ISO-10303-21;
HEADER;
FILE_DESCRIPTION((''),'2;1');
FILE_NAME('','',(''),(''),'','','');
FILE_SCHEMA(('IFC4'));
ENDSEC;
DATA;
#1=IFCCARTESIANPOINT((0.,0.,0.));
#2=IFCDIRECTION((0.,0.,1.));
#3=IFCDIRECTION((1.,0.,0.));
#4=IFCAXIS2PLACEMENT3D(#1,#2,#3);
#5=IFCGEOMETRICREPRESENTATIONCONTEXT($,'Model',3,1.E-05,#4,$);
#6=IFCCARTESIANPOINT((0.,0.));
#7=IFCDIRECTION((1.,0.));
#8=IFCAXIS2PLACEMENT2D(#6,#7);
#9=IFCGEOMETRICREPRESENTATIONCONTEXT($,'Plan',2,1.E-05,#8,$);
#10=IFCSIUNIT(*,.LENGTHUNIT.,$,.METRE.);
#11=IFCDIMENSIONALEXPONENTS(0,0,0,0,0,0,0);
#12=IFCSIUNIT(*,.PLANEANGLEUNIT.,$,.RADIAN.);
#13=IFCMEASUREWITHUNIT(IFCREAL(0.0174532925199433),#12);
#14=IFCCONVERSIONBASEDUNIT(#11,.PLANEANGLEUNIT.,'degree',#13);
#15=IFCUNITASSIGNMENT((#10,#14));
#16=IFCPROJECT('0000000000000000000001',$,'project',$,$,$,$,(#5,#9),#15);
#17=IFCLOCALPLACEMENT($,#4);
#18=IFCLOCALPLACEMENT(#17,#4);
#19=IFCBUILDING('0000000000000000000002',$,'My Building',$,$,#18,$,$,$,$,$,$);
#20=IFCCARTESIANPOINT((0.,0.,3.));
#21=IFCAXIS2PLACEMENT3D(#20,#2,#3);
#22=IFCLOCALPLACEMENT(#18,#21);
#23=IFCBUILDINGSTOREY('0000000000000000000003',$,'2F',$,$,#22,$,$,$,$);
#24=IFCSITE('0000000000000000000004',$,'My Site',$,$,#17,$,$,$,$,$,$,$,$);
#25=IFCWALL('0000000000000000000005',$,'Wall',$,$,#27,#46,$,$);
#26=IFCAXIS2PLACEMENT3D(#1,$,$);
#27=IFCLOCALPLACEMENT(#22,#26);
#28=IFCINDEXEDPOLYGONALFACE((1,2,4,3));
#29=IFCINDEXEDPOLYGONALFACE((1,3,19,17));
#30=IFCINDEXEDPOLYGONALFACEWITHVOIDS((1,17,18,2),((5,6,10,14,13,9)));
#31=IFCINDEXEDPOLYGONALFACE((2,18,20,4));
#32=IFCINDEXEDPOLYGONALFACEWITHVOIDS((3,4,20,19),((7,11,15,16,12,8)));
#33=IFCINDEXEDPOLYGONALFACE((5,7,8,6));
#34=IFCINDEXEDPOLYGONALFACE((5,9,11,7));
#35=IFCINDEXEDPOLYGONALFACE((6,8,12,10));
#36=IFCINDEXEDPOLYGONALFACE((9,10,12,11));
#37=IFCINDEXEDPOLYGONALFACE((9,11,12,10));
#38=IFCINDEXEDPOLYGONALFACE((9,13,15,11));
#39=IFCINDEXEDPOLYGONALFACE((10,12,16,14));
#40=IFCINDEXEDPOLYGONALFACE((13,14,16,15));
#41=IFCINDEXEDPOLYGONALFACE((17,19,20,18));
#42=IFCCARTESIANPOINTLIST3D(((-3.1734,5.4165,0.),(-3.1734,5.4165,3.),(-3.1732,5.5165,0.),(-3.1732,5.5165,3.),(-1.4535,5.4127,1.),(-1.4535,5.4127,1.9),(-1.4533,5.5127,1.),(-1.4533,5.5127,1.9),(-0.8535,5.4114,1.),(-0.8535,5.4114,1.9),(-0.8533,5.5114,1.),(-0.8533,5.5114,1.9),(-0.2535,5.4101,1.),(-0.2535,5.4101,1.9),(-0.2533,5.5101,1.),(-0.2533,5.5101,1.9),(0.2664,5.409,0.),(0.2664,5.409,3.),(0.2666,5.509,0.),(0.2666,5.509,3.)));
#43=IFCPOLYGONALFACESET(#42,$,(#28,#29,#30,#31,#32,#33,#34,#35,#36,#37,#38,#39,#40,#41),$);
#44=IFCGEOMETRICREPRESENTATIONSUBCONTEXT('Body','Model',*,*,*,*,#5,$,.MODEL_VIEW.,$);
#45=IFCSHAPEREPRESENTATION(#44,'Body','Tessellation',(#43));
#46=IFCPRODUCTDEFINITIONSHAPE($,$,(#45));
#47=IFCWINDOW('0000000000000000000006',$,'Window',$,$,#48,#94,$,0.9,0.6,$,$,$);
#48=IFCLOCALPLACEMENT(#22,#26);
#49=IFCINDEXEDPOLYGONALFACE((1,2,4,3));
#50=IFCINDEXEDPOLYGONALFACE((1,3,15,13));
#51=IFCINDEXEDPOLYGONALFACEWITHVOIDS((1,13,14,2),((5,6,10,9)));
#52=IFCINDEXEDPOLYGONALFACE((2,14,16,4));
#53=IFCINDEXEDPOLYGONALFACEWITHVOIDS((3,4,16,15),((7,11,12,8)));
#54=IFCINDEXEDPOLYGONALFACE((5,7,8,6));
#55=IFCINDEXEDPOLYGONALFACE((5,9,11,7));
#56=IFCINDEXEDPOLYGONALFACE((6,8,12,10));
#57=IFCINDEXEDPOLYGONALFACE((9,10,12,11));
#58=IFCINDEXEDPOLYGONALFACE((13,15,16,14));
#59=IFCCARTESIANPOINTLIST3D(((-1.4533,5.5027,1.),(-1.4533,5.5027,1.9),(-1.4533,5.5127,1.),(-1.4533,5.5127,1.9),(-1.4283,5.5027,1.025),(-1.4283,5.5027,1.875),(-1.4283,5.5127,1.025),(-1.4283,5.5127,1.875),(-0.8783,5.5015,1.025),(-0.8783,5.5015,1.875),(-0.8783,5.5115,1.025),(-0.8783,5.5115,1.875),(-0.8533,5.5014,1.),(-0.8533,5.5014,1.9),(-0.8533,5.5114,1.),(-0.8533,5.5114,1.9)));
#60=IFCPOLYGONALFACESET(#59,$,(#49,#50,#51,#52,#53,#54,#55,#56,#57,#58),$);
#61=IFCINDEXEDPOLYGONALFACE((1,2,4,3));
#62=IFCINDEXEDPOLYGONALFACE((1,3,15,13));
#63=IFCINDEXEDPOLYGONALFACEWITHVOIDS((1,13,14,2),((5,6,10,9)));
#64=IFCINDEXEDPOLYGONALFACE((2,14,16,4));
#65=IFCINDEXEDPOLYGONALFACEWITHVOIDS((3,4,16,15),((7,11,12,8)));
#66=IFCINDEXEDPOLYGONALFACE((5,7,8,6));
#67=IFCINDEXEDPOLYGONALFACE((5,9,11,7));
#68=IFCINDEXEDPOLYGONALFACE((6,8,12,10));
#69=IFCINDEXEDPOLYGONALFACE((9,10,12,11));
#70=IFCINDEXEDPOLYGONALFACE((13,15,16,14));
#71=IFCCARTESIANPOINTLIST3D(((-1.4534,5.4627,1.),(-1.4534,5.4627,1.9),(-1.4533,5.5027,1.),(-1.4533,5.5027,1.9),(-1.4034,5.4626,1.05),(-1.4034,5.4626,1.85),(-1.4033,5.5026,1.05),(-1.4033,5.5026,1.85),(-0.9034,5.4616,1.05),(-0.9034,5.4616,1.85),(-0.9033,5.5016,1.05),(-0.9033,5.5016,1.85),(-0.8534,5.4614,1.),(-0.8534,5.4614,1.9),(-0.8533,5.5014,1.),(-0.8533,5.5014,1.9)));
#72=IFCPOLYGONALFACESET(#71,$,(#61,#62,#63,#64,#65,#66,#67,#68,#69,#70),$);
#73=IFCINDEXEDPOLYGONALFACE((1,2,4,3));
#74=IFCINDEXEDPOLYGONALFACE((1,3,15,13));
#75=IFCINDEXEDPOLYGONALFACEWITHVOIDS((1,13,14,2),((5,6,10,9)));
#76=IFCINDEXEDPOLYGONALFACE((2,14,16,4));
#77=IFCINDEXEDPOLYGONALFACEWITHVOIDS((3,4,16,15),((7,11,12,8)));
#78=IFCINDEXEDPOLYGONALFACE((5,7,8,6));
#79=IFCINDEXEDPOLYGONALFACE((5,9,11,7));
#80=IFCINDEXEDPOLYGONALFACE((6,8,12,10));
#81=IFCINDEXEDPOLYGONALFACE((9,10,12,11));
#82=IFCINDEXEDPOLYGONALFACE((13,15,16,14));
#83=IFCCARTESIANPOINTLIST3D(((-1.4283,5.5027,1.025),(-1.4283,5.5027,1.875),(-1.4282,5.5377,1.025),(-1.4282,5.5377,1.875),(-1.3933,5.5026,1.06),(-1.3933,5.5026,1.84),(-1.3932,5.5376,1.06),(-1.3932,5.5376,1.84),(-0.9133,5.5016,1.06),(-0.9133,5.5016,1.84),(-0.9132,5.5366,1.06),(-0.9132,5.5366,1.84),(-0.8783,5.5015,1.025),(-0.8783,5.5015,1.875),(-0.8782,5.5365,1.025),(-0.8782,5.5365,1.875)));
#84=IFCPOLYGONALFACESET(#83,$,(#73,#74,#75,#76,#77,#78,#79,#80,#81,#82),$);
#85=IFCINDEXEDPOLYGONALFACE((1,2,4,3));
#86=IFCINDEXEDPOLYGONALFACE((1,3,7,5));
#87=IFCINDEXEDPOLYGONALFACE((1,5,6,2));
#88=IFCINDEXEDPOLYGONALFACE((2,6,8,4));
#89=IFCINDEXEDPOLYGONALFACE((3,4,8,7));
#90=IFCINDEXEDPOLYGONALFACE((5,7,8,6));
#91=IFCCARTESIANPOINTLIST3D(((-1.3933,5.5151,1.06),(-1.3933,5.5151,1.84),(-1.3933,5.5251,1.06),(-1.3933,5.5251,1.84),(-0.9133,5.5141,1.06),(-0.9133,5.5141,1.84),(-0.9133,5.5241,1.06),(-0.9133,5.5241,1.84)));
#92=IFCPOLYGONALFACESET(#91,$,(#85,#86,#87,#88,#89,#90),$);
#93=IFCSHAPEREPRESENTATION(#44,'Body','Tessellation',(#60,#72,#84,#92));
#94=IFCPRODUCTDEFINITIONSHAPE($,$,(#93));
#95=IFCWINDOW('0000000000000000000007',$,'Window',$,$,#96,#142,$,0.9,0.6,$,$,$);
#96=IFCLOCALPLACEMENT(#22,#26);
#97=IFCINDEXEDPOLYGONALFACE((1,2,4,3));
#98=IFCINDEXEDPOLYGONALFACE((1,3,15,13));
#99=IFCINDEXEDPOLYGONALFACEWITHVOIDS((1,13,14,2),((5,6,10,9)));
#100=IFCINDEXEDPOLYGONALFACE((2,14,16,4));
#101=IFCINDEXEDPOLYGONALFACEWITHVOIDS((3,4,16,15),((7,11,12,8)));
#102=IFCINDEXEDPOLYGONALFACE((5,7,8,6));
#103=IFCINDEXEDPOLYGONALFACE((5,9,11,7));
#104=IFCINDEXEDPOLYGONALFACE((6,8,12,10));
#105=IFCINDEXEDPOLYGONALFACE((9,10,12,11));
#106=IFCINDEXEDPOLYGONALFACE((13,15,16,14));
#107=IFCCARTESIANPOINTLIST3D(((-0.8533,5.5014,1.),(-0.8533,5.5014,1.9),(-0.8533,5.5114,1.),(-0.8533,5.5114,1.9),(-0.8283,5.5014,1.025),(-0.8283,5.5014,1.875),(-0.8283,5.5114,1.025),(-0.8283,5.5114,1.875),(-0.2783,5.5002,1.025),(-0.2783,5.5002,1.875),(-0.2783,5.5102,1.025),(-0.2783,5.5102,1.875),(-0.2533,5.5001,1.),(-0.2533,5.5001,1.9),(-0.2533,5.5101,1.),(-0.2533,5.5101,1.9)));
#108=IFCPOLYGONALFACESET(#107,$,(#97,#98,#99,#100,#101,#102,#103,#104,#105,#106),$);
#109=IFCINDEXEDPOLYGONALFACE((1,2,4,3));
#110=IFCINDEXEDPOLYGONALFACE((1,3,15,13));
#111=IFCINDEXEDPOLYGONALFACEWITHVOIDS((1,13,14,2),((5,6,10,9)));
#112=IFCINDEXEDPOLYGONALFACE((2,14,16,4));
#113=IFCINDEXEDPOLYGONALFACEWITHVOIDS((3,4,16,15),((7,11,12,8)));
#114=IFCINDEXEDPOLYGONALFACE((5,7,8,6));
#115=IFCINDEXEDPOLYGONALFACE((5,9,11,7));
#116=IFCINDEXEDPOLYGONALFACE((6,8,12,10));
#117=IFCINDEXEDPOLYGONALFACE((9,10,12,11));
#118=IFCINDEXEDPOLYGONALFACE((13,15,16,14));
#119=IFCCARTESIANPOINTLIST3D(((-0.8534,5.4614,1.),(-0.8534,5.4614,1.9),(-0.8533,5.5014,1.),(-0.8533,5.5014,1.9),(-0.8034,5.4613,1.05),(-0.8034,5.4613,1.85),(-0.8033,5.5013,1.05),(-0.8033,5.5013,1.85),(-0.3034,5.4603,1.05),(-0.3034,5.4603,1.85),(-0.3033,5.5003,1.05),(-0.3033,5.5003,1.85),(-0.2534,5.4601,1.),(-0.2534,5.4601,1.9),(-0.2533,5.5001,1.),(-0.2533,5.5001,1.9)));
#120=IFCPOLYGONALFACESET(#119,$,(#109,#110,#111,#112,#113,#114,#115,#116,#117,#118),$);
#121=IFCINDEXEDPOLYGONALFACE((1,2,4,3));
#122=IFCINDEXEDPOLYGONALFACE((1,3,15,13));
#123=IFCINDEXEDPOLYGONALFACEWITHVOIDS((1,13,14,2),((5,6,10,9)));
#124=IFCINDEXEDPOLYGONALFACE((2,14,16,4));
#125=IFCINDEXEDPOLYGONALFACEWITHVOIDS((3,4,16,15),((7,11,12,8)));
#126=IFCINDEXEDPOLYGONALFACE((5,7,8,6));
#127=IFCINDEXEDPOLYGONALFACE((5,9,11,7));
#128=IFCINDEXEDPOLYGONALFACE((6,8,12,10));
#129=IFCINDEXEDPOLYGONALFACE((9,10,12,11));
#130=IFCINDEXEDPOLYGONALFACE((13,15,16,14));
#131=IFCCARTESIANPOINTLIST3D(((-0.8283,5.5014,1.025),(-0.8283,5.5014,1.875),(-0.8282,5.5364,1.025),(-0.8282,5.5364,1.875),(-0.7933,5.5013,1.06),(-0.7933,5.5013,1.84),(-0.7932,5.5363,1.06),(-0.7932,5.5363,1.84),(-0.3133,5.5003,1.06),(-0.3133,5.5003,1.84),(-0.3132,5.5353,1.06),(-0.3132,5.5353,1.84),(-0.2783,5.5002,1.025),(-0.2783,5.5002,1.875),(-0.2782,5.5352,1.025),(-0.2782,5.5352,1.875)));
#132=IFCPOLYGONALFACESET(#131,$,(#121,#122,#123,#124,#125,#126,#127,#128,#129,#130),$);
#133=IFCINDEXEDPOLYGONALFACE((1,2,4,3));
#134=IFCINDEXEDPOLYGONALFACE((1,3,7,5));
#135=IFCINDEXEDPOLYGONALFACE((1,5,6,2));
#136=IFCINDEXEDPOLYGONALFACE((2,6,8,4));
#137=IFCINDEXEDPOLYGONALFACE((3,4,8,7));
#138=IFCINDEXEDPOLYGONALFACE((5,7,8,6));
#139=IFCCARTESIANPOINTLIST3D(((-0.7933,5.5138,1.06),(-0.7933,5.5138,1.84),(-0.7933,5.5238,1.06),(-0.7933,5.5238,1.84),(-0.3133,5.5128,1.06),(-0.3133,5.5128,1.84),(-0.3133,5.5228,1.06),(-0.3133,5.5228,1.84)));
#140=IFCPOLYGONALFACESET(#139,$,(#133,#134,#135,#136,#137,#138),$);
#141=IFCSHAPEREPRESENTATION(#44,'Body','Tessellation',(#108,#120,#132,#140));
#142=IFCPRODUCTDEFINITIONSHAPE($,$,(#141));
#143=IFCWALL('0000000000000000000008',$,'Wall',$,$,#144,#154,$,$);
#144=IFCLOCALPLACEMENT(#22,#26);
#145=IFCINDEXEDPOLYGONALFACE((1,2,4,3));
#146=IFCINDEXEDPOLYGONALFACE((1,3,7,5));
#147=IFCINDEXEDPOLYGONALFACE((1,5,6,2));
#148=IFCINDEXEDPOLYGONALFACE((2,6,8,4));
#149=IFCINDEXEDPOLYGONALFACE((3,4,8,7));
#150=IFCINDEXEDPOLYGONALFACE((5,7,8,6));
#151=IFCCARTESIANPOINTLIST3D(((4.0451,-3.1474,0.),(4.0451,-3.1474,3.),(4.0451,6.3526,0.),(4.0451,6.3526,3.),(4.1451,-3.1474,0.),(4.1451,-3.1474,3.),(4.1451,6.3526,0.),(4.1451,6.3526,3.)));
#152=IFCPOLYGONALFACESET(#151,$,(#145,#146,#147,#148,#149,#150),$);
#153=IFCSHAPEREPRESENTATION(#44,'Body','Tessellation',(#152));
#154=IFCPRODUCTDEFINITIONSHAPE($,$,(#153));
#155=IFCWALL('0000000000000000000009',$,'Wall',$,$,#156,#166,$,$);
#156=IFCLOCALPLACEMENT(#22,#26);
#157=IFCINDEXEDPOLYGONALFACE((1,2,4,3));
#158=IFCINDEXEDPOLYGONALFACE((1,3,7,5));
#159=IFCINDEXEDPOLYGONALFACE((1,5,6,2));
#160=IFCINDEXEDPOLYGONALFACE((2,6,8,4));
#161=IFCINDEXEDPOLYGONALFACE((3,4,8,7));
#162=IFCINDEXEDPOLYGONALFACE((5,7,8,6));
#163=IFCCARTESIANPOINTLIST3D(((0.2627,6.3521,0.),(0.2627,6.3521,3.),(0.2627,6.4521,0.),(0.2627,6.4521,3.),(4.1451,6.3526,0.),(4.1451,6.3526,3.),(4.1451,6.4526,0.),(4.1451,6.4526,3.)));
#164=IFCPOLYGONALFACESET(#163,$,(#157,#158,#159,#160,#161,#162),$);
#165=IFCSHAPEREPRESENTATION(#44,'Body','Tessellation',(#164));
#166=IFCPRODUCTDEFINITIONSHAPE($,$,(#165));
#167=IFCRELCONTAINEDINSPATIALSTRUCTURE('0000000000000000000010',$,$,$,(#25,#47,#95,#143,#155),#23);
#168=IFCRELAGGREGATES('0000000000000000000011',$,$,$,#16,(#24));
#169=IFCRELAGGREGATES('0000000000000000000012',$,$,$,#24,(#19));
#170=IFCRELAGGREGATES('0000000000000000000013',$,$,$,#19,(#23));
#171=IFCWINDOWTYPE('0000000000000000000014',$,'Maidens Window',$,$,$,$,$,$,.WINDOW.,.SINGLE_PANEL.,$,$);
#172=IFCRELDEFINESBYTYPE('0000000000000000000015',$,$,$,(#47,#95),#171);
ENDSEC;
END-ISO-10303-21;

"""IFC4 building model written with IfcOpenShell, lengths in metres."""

from ifc_helpers import new_model, entity, si_unit, converted_unit, frame, origin_with_axes, origin_2d_with_axis, place, context, subcontext, project, spatial, line, indexed_curve, outline, extrude, shape, source, transform, mapped, type_object, type_shapes, element, fill, save


model = new_model("IFC4")

# Units and contexts
model_context = context("Model", 3, precision=1e-05, world=origin_with_axes())
plan_context = context("Plan", 2, precision=1e-05, world=origin_2d_with_axis())
body_context_1 = subcontext(model_context, "Body", "Model", "MODEL_VIEW")
body_context_2 = subcontext(plan_context, "Body", "Plan", "PLAN_VIEW")
ifc_project = project(units=[si_unit("LENGTHUNIT", "METRE"), converted_unit("PLANEANGLEUNIT", "degree", entity("IfcReal", 0.0174532925199433), si_unit("PLANEANGLEUNIT", "RADIAN"), dimensions=[0, 0, 0, 0, 0, 0, 0])], contexts=[model_context, plan_context])

# Site, building, storey
site_placement = place(None, origin_with_axes())
site = spatial("IfcSite", under=ifc_project, at=site_placement, Name="My Site")
building_placement = place(site_placement, origin_with_axes())
building = spatial("IfcBuilding", under=site, at=building_placement, Name="My Building")
storey_placement = place(building_placement, frame((0.0, 0.0, 3.0), z_axis=(0.0, 0.0, 1.0), x_axis=(1.0, 0.0, 0.0)))
storey = spatial("IfcBuildingStorey", under=building, at=storey_placement, Name="2F")

# Shared definitions
shared_shape_1 = source(origin_with_axes(), body_context_1, "Body", "SweptSolid", [
    extrude(outline(indexed_curve([(0.0, 0.0), (0.6, 0.0), (0.6, 0.9), (0.0, 0.9)], segments=[line(1, 2, 3, 4, 1)])), frame((0.0, -0.6, 0.0), z_axis=(0.0, -1.0, 0.0), x_axis=(1.0, 0.0, 0.0)), (0.0, 0.0, -1.0), 1.2),
])
window_type_1 = type_object("IfcWindowType", Name="Maidens Window", PartitioningType="SINGLE_PANEL", PredefinedType="WINDOW")
shared_shape_2 = source(origin_with_axes(), body_context_1, "Body", "SweptSolid", [
    extrude(outline(indexed_curve([(0.0, 0.0), (0.6, 0.0), (0.6, 0.9), (0.0, 0.9)], segments=[line(1, 2, 3, 4, 1)]), holes=[indexed_curve([(0.025, 0.025), (0.575, 0.025), (0.575, 0.875), (0.025, 0.875)], segments=[line(1, 2, 3, 4, 1)])]), frame((0.0, 0.09, 0.0), z_axis=(0.0, -1.0, 0.0), x_axis=(1.0, 0.0, 0.0)), (0.0, 0.0, -1.0), 0.01),
    extrude(outline(indexed_curve([(0.0, 0.0), (0.6, 0.0), (0.6, 0.9), (0.0, 0.9)], segments=[line(1, 2, 3, 4, 1)]), holes=[indexed_curve([(0.05, 0.05), (0.55, 0.05), (0.55, 0.85), (0.05, 0.85)], segments=[line(1, 2, 3, 4, 1)])]), frame((0.0, 0.05, 0.0), z_axis=(0.0, -1.0, 0.0), x_axis=(1.0, 0.0, 0.0)), (0.0, 0.0, -1.0), 0.04),
    extrude(outline(indexed_curve([(0.0, 0.0), (0.55, 0.0), (0.55, 0.85), (0.0, 0.85)], segments=[line(1, 2, 3, 4, 1)]), holes=[indexed_curve([(0.035, 0.035), (0.515, 0.035), (0.515, 0.815), (0.035, 0.815)], segments=[line(1, 2, 3, 4, 1)])]), frame((0.025, 0.09, 0.025), z_axis=(0.0, -1.0, 0.0), x_axis=(1.0, 0.0, 0.0)), (0.0, 0.0, -1.0), 0.035),
    extrude(outline(indexed_curve([(0.035, 0.035), (0.515, 0.035), (0.515, 0.815), (0.035, 0.815)], segments=[line(1, 2, 3, 4, 1)])), frame((0.025, 0.1025, 0.025), z_axis=(0.0, -1.0, 0.0), x_axis=(1.0, 0.0, 0.0)), (0.0, 0.0, -1.0), 0.01),
])
shared_shape_3 = source(origin_with_axes(), body_context_2, "Body", "Curve2D", [
    entity("IfcIndexedPolyCurve", entity("IfcCartesianPointList2D", [[0.05, 0.05], [0.55, 0.05]])),
    entity("IfcIndexedPolyCurve", entity("IfcCartesianPointList2D", [[0.0, 0.1], [0.025, 0.1], [0.025, 0.09], [0.05, 0.09], [0.05, 0.05], [0.0, 0.05]]), [entity("IfcLineIndex", [1, 2, 3, 4, 5, 6, 1])]),
    entity("IfcIndexedPolyCurve", entity("IfcCartesianPointList2D", [[0.6, 0.1], [0.575, 0.1], [0.575, 0.09], [0.55, 0.09], [0.55, 0.05], [0.6, 0.05]]), [entity("IfcLineIndex", [1, 2, 3, 4, 5, 6, 1])]),
    entity("IfcIndexedPolyCurve", entity("IfcCartesianPointList2D", [[0.025, 0.09], [0.06, 0.09], [0.06, 0.125], [0.025, 0.125]]), [entity("IfcLineIndex", [1, 2, 3, 4, 1])]),
    entity("IfcIndexedPolyCurve", entity("IfcCartesianPointList2D", [[0.575, 0.09], [0.54, 0.09], [0.54, 0.125], [0.575, 0.125]]), [entity("IfcLineIndex", [1, 2, 3, 4, 1])]),
    entity("IfcIndexedPolyCurve", entity("IfcCartesianPointList2D", [[0.06, 0.09], [0.54, 0.09]])),
    entity("IfcIndexedPolyCurve", entity("IfcCartesianPointList2D", [[0.06, 0.125], [0.54, 0.125]])),
    entity("IfcIndexedPolyCurve", entity("IfcCartesianPointList2D", [[0.06, 0.1075], [0.54, 0.1075]])),
])
type_shapes(window_type_1, [shared_shape_2, shared_shape_3])

# Wall, openings, windows
wall_1_placement = place(storey_placement, frame((-3.1734, 5.4165, 0.0), z_axis=(0.0, 0.0, 1.0), x_axis=(0.999998, -0.002166, 0.0)))
wall_1 = element("IfcWall", 1, at=wall_1_placement, inside=storey, Name="Wall", context=body_context_1, shape_type="SweptSolid", body=[
    extrude(outline(indexed_curve([(0.0, 0.0), (0.0, 0.1), (3.4398, 0.1), (3.4398, 0.0)], segments=[line(1, 2, 3, 4, 1)])), origin_with_axes(), (0.0, 0.0, 1.0), 3.0),
])
opening_1_placement = place(wall_1_placement, frame((1.7199, 0.0, 1.0), z_axis=(0.0, 0.0, 1.0), x_axis=(1.0, 0.0, 0.0)))
opening_1 = element("IfcOpeningElement", 2, at=opening_1_placement, cuts=wall_1, PredefinedType="OPENING", context=body_context_1, shape_type="MappedRepresentation", body=[
    mapped(shared_shape_1, transform((0.0, 0.0, 0.0), x_axis=(1.0, 0.0, 0.0), y_axis=(0.0, 1.0, 0.0), z_axis=(0.0, 0.0, 1.0), scale=1.0)),
])
opening_2_placement = place(wall_1_placement, frame((2.3199, 0.0, 1.0), z_axis=(0.0, 0.0, 1.0), x_axis=(1.0, 0.0, 0.0)))
opening_2 = element("IfcOpeningElement", 3, at=opening_2_placement, cuts=wall_1, PredefinedType="OPENING", context=body_context_1, shape_type="MappedRepresentation", body=[
    mapped(shared_shape_1, transform((0.0, 0.0, 0.0), x_axis=(1.0, 0.0, 0.0), y_axis=(0.0, 1.0, 0.0), z_axis=(0.0, 0.0, 1.0), scale=1.0)),
])
window_1_placement = place(opening_1_placement, origin_with_axes())
window_1 = element("IfcWindow", 4, at=window_1_placement, inside=storey, type_object=window_type_1, Name="Window", OverallHeight=0.9, OverallWidth=0.6, shapes=[
    shape(body_context_1, "Body", "MappedRepresentation", [mapped(shared_shape_2, transform((0.0, 0.0, 0.0), x_axis=(1.0, 0.0, 0.0), y_axis=(0.0, 1.0, 0.0), z_axis=(0.0, 0.0, 1.0), scale=1.0))]),
    shape(body_context_2, "Body", "MappedRepresentation", [mapped(shared_shape_3, transform((0.0, 0.0, 0.0), x_axis=(1.0, 0.0, 0.0), y_axis=(0.0, 1.0, 0.0), z_axis=(0.0, 0.0, 1.0), scale=1.0))]),
])
fill(opening_1, window_1)
window_2_placement = place(opening_2_placement, origin_with_axes())
window_2 = element("IfcWindow", 5, at=window_2_placement, inside=storey, type_object=window_type_1, Name="Window", OverallHeight=0.9, OverallWidth=0.6, shapes=[
    shape(body_context_1, "Body", "MappedRepresentation", [mapped(shared_shape_2, transform((0.0, 0.0, 0.0), x_axis=(1.0, 0.0, 0.0), y_axis=(0.0, 1.0, 0.0), z_axis=(0.0, 0.0, 1.0), scale=1.0))]),
    shape(body_context_2, "Body", "MappedRepresentation", [mapped(shared_shape_3, transform((0.0, 0.0, 0.0), x_axis=(1.0, 0.0, 0.0), y_axis=(0.0, 1.0, 0.0), z_axis=(0.0, 0.0, 1.0), scale=1.0))]),
])
fill(opening_2, window_2)

# Walls
wall_2_placement = place(storey_placement, frame((4.0451, 6.3526, 0.0), z_axis=(0.0, 0.0, 1.0), x_axis=(0.0, -1.0, 0.0)))
element("IfcWall", 6, at=wall_2_placement, inside=storey, Name="Wall", context=body_context_1, shape_type="SweptSolid", body=[
    extrude(outline(indexed_curve([(0.0, 0.0), (0.0, 0.1), (9.5, 0.1), (9.5, 0.0)], segments=[line(1, 2, 3, 4, 1)])), origin_with_axes(), (0.0, 0.0, 1.0), 3.0),
])
wall_3_placement = place(storey_placement, frame((0.2627, 6.3521, 0.0), z_axis=(0.0, 0.0, 1.0), x_axis=(1.0, 0.000113, 0.0)))
element("IfcWall", 7, at=wall_3_placement, inside=storey, Name="Wall", context=body_context_1, shape_type="SweptSolid", body=[
    extrude(outline(indexed_curve([(0.0, 0.0), (0.0, 0.1), (3.8824, 0.1), (3.8824, 0.0)], segments=[line(1, 2, 3, 4, 1)])), origin_with_axes(), (0.0, 0.0, 1.0), 3.0),
])

save(model, "model.ifc")
